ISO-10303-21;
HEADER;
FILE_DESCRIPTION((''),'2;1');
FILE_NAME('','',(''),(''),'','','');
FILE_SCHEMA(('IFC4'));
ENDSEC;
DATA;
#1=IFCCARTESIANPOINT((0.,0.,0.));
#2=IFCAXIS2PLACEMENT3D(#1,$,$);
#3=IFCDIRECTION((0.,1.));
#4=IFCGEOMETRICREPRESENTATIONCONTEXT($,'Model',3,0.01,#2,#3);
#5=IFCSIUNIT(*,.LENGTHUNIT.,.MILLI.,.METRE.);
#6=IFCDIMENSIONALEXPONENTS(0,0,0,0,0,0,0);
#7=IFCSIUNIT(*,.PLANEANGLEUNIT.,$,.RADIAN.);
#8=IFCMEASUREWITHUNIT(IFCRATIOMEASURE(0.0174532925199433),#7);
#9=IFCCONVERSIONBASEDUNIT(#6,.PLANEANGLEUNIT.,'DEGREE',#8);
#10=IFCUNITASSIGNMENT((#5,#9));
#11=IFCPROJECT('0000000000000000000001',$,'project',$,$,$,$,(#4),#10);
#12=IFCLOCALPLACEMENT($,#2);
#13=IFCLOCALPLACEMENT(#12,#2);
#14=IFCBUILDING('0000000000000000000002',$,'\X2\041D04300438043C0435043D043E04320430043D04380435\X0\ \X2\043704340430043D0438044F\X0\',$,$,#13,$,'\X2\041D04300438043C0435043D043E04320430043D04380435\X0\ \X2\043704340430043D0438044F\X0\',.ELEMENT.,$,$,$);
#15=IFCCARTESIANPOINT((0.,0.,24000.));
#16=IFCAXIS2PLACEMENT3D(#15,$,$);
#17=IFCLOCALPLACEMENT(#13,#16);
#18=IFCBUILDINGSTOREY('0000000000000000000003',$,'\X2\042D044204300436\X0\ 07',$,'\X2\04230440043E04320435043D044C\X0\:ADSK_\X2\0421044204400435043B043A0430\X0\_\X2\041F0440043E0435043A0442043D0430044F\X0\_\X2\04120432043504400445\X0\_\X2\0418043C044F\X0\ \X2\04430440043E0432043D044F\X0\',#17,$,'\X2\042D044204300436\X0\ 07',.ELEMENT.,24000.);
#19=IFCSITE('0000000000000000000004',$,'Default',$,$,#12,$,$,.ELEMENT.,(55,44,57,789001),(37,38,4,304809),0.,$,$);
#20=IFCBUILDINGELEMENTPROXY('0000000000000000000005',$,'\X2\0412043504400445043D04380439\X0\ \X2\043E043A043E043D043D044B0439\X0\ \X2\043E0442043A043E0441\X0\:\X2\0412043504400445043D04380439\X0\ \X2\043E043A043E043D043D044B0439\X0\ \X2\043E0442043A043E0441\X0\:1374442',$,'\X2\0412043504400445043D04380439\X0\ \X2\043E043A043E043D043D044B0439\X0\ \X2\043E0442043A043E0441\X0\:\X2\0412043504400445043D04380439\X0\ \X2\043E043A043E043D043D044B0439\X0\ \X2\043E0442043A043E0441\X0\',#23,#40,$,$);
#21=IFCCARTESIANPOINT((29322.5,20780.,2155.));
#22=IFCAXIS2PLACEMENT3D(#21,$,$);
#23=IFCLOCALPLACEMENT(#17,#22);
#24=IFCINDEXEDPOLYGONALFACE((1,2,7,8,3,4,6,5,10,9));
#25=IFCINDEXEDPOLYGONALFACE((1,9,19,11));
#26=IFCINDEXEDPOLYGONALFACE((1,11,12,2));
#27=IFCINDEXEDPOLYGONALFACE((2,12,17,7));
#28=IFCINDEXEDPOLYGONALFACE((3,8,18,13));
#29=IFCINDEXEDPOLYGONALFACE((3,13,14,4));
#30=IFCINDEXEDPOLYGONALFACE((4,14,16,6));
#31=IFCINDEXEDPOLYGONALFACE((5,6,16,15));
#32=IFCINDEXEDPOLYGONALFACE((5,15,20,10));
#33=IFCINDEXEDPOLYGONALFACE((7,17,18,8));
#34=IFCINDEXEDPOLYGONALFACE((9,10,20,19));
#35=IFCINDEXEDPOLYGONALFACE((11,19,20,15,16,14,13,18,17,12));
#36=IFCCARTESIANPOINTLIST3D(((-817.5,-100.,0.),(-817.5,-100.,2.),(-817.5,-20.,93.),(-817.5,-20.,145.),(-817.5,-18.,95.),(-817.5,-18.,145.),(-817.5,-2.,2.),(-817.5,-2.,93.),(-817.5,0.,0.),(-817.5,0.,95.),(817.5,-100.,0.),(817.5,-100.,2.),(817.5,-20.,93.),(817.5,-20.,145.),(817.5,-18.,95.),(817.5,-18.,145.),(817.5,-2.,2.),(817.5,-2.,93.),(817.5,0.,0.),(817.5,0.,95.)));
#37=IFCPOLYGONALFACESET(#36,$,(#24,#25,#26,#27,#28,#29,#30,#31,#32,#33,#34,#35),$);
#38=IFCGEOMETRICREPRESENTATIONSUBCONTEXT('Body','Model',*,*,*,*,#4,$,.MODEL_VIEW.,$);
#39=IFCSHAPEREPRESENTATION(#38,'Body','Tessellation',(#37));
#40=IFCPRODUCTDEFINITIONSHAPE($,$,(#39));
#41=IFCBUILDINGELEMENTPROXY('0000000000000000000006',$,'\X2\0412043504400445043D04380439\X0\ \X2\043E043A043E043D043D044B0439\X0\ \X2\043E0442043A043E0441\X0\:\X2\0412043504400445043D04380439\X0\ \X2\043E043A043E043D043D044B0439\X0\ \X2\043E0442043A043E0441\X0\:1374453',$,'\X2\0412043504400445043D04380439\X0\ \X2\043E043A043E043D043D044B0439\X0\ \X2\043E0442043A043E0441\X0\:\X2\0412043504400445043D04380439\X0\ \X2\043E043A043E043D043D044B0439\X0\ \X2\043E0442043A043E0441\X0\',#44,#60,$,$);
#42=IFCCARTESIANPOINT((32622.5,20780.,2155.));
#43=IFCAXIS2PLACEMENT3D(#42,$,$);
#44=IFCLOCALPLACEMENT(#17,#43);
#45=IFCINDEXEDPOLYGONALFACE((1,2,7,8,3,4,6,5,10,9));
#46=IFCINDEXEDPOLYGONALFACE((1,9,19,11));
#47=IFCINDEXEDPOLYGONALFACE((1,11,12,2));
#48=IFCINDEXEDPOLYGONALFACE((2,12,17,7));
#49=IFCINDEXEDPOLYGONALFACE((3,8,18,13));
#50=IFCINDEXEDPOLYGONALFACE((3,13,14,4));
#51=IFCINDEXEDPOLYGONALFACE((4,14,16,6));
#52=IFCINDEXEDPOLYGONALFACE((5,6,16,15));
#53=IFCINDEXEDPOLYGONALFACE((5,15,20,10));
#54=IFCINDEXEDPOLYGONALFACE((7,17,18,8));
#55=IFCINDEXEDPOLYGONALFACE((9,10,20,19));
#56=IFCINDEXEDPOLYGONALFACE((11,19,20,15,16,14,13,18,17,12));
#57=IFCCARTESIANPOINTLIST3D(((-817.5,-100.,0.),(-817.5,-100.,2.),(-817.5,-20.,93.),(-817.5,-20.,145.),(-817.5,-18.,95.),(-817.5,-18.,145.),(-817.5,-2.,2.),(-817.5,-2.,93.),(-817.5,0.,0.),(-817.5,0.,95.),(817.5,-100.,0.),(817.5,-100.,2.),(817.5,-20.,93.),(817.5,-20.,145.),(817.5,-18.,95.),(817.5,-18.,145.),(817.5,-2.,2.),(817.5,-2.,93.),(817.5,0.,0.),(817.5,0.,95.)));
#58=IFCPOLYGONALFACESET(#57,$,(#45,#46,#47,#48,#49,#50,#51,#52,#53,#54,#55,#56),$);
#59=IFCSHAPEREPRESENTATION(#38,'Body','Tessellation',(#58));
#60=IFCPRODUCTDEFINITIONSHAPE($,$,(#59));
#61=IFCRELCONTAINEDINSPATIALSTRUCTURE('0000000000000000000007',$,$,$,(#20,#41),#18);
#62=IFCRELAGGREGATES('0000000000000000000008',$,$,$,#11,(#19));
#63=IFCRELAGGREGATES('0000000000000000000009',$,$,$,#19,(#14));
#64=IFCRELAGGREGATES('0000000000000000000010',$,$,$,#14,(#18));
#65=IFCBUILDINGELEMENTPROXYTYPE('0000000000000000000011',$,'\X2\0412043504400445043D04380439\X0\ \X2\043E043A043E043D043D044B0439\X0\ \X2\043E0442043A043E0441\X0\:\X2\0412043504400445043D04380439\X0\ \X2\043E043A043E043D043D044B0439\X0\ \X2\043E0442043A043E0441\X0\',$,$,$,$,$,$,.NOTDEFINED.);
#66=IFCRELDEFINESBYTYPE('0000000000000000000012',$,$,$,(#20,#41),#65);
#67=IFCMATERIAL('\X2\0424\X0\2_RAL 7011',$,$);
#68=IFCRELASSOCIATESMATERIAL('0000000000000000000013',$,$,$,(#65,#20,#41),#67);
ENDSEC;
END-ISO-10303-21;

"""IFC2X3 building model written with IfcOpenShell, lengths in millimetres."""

from ifc_helpers import new_model, entity, si_unit, converted_unit, direction, frame, origin, place, context, subcontext, project, spatial, polyline, outline, extrude, source, transform, mapped, material, type_object, type_shapes, element, save


model = new_model("IFC2X3")

# Units and contexts
model_context = context("Model", 3, precision=0.01, world=origin(), true_north=direction((0.0, 1.0)))
body_context = subcontext(model_context, "Body", "Model", "MODEL_VIEW")
ifc_project = project(units=[si_unit("LENGTHUNIT", "METRE", prefix="MILLI"), converted_unit("PLANEANGLEUNIT", "DEGREE", entity("IfcRatioMeasure", 0.0174532925199433), si_unit("PLANEANGLEUNIT", "RADIAN"), dimensions=[0, 0, 0, 0, 0, 0, 0])], contexts=[model_context])

# Site, building, storey
site_placement = place(None, origin())
site = spatial("IfcSite", under=ifc_project, at=site_placement, Name="Default", CompositionType="ELEMENT", RefLatitude=(55, 44, 57, 789001), RefLongitude=(37, 38, 4, 304809), RefElevation=0.0)
building_placement = place(site_placement, origin())
building = spatial("IfcBuilding", under=site, at=building_placement, Name="Наименование здания", LongName="Наименование здания", CompositionType="ELEMENT")
storey_placement = place(building_placement, frame((0.0, 0.0, 24000.0)))
storey = spatial("IfcBuildingStorey", under=building, at=storey_placement, Name="Этаж 07", ObjectType="Уровень:ADSK_Стрелка_Проектная_Вверх_Имя уровня", LongName="Этаж 07", CompositionType="ELEMENT", Elevation=24000.0)

# Building element proxies
ifc_material_1 = material(Name="Ф2_RAL 7011")
building_element_proxy_type_1 = type_object("IfcBuildingElementProxyType", Name="Верхний оконный откос:Верхний оконный откос", PredefinedType="NOTDEFINED", material=ifc_material_1)
shared_shape_1 = source(origin(), body_context, "Body", "SweptSolid", [
    extrude(outline(polyline([(28.0, -10.0), (78.0, -10.0), (78.0, -8.0), (26.0, -8.0), (26.0, -26.0), (-65.0, -26.0), (-65.0, 72.0), (-67.0, 72.0), (-67.0, -28.0), (28.0, -28.0), (28.0, -10.0)])), frame((-817.5, -28.0, 67.0), z_axis=(1.0, 0.0, 0.0), x_axis=(0.0, 0.0, 1.0)), (0.0, 0.0, 1.0), 1635.0),
])
type_shapes(building_element_proxy_type_1, [shared_shape_1])
for number, where, name in (
    (1, (29322.5, 20780.0, 2155.0), "Верхний оконный откос:Верхний оконный откос:1374442"),
    (2, (32622.5, 20780.0, 2155.0), "Верхний оконный откос:Верхний оконный откос:1374453"),
):
    element("IfcBuildingElementProxy", number, at=place(storey_placement, frame(where)), inside=storey, type_object=building_element_proxy_type_1, material=ifc_material_1, Name=name, ObjectType="Верхний оконный откос:Верхний оконный откос", context=body_context, shape_type="MappedRepresentation", body=[
        mapped(shared_shape_1, transform((0.0, 0.0, 0.0), scale=1.0)),
    ])

save(model, "model.ifc")
